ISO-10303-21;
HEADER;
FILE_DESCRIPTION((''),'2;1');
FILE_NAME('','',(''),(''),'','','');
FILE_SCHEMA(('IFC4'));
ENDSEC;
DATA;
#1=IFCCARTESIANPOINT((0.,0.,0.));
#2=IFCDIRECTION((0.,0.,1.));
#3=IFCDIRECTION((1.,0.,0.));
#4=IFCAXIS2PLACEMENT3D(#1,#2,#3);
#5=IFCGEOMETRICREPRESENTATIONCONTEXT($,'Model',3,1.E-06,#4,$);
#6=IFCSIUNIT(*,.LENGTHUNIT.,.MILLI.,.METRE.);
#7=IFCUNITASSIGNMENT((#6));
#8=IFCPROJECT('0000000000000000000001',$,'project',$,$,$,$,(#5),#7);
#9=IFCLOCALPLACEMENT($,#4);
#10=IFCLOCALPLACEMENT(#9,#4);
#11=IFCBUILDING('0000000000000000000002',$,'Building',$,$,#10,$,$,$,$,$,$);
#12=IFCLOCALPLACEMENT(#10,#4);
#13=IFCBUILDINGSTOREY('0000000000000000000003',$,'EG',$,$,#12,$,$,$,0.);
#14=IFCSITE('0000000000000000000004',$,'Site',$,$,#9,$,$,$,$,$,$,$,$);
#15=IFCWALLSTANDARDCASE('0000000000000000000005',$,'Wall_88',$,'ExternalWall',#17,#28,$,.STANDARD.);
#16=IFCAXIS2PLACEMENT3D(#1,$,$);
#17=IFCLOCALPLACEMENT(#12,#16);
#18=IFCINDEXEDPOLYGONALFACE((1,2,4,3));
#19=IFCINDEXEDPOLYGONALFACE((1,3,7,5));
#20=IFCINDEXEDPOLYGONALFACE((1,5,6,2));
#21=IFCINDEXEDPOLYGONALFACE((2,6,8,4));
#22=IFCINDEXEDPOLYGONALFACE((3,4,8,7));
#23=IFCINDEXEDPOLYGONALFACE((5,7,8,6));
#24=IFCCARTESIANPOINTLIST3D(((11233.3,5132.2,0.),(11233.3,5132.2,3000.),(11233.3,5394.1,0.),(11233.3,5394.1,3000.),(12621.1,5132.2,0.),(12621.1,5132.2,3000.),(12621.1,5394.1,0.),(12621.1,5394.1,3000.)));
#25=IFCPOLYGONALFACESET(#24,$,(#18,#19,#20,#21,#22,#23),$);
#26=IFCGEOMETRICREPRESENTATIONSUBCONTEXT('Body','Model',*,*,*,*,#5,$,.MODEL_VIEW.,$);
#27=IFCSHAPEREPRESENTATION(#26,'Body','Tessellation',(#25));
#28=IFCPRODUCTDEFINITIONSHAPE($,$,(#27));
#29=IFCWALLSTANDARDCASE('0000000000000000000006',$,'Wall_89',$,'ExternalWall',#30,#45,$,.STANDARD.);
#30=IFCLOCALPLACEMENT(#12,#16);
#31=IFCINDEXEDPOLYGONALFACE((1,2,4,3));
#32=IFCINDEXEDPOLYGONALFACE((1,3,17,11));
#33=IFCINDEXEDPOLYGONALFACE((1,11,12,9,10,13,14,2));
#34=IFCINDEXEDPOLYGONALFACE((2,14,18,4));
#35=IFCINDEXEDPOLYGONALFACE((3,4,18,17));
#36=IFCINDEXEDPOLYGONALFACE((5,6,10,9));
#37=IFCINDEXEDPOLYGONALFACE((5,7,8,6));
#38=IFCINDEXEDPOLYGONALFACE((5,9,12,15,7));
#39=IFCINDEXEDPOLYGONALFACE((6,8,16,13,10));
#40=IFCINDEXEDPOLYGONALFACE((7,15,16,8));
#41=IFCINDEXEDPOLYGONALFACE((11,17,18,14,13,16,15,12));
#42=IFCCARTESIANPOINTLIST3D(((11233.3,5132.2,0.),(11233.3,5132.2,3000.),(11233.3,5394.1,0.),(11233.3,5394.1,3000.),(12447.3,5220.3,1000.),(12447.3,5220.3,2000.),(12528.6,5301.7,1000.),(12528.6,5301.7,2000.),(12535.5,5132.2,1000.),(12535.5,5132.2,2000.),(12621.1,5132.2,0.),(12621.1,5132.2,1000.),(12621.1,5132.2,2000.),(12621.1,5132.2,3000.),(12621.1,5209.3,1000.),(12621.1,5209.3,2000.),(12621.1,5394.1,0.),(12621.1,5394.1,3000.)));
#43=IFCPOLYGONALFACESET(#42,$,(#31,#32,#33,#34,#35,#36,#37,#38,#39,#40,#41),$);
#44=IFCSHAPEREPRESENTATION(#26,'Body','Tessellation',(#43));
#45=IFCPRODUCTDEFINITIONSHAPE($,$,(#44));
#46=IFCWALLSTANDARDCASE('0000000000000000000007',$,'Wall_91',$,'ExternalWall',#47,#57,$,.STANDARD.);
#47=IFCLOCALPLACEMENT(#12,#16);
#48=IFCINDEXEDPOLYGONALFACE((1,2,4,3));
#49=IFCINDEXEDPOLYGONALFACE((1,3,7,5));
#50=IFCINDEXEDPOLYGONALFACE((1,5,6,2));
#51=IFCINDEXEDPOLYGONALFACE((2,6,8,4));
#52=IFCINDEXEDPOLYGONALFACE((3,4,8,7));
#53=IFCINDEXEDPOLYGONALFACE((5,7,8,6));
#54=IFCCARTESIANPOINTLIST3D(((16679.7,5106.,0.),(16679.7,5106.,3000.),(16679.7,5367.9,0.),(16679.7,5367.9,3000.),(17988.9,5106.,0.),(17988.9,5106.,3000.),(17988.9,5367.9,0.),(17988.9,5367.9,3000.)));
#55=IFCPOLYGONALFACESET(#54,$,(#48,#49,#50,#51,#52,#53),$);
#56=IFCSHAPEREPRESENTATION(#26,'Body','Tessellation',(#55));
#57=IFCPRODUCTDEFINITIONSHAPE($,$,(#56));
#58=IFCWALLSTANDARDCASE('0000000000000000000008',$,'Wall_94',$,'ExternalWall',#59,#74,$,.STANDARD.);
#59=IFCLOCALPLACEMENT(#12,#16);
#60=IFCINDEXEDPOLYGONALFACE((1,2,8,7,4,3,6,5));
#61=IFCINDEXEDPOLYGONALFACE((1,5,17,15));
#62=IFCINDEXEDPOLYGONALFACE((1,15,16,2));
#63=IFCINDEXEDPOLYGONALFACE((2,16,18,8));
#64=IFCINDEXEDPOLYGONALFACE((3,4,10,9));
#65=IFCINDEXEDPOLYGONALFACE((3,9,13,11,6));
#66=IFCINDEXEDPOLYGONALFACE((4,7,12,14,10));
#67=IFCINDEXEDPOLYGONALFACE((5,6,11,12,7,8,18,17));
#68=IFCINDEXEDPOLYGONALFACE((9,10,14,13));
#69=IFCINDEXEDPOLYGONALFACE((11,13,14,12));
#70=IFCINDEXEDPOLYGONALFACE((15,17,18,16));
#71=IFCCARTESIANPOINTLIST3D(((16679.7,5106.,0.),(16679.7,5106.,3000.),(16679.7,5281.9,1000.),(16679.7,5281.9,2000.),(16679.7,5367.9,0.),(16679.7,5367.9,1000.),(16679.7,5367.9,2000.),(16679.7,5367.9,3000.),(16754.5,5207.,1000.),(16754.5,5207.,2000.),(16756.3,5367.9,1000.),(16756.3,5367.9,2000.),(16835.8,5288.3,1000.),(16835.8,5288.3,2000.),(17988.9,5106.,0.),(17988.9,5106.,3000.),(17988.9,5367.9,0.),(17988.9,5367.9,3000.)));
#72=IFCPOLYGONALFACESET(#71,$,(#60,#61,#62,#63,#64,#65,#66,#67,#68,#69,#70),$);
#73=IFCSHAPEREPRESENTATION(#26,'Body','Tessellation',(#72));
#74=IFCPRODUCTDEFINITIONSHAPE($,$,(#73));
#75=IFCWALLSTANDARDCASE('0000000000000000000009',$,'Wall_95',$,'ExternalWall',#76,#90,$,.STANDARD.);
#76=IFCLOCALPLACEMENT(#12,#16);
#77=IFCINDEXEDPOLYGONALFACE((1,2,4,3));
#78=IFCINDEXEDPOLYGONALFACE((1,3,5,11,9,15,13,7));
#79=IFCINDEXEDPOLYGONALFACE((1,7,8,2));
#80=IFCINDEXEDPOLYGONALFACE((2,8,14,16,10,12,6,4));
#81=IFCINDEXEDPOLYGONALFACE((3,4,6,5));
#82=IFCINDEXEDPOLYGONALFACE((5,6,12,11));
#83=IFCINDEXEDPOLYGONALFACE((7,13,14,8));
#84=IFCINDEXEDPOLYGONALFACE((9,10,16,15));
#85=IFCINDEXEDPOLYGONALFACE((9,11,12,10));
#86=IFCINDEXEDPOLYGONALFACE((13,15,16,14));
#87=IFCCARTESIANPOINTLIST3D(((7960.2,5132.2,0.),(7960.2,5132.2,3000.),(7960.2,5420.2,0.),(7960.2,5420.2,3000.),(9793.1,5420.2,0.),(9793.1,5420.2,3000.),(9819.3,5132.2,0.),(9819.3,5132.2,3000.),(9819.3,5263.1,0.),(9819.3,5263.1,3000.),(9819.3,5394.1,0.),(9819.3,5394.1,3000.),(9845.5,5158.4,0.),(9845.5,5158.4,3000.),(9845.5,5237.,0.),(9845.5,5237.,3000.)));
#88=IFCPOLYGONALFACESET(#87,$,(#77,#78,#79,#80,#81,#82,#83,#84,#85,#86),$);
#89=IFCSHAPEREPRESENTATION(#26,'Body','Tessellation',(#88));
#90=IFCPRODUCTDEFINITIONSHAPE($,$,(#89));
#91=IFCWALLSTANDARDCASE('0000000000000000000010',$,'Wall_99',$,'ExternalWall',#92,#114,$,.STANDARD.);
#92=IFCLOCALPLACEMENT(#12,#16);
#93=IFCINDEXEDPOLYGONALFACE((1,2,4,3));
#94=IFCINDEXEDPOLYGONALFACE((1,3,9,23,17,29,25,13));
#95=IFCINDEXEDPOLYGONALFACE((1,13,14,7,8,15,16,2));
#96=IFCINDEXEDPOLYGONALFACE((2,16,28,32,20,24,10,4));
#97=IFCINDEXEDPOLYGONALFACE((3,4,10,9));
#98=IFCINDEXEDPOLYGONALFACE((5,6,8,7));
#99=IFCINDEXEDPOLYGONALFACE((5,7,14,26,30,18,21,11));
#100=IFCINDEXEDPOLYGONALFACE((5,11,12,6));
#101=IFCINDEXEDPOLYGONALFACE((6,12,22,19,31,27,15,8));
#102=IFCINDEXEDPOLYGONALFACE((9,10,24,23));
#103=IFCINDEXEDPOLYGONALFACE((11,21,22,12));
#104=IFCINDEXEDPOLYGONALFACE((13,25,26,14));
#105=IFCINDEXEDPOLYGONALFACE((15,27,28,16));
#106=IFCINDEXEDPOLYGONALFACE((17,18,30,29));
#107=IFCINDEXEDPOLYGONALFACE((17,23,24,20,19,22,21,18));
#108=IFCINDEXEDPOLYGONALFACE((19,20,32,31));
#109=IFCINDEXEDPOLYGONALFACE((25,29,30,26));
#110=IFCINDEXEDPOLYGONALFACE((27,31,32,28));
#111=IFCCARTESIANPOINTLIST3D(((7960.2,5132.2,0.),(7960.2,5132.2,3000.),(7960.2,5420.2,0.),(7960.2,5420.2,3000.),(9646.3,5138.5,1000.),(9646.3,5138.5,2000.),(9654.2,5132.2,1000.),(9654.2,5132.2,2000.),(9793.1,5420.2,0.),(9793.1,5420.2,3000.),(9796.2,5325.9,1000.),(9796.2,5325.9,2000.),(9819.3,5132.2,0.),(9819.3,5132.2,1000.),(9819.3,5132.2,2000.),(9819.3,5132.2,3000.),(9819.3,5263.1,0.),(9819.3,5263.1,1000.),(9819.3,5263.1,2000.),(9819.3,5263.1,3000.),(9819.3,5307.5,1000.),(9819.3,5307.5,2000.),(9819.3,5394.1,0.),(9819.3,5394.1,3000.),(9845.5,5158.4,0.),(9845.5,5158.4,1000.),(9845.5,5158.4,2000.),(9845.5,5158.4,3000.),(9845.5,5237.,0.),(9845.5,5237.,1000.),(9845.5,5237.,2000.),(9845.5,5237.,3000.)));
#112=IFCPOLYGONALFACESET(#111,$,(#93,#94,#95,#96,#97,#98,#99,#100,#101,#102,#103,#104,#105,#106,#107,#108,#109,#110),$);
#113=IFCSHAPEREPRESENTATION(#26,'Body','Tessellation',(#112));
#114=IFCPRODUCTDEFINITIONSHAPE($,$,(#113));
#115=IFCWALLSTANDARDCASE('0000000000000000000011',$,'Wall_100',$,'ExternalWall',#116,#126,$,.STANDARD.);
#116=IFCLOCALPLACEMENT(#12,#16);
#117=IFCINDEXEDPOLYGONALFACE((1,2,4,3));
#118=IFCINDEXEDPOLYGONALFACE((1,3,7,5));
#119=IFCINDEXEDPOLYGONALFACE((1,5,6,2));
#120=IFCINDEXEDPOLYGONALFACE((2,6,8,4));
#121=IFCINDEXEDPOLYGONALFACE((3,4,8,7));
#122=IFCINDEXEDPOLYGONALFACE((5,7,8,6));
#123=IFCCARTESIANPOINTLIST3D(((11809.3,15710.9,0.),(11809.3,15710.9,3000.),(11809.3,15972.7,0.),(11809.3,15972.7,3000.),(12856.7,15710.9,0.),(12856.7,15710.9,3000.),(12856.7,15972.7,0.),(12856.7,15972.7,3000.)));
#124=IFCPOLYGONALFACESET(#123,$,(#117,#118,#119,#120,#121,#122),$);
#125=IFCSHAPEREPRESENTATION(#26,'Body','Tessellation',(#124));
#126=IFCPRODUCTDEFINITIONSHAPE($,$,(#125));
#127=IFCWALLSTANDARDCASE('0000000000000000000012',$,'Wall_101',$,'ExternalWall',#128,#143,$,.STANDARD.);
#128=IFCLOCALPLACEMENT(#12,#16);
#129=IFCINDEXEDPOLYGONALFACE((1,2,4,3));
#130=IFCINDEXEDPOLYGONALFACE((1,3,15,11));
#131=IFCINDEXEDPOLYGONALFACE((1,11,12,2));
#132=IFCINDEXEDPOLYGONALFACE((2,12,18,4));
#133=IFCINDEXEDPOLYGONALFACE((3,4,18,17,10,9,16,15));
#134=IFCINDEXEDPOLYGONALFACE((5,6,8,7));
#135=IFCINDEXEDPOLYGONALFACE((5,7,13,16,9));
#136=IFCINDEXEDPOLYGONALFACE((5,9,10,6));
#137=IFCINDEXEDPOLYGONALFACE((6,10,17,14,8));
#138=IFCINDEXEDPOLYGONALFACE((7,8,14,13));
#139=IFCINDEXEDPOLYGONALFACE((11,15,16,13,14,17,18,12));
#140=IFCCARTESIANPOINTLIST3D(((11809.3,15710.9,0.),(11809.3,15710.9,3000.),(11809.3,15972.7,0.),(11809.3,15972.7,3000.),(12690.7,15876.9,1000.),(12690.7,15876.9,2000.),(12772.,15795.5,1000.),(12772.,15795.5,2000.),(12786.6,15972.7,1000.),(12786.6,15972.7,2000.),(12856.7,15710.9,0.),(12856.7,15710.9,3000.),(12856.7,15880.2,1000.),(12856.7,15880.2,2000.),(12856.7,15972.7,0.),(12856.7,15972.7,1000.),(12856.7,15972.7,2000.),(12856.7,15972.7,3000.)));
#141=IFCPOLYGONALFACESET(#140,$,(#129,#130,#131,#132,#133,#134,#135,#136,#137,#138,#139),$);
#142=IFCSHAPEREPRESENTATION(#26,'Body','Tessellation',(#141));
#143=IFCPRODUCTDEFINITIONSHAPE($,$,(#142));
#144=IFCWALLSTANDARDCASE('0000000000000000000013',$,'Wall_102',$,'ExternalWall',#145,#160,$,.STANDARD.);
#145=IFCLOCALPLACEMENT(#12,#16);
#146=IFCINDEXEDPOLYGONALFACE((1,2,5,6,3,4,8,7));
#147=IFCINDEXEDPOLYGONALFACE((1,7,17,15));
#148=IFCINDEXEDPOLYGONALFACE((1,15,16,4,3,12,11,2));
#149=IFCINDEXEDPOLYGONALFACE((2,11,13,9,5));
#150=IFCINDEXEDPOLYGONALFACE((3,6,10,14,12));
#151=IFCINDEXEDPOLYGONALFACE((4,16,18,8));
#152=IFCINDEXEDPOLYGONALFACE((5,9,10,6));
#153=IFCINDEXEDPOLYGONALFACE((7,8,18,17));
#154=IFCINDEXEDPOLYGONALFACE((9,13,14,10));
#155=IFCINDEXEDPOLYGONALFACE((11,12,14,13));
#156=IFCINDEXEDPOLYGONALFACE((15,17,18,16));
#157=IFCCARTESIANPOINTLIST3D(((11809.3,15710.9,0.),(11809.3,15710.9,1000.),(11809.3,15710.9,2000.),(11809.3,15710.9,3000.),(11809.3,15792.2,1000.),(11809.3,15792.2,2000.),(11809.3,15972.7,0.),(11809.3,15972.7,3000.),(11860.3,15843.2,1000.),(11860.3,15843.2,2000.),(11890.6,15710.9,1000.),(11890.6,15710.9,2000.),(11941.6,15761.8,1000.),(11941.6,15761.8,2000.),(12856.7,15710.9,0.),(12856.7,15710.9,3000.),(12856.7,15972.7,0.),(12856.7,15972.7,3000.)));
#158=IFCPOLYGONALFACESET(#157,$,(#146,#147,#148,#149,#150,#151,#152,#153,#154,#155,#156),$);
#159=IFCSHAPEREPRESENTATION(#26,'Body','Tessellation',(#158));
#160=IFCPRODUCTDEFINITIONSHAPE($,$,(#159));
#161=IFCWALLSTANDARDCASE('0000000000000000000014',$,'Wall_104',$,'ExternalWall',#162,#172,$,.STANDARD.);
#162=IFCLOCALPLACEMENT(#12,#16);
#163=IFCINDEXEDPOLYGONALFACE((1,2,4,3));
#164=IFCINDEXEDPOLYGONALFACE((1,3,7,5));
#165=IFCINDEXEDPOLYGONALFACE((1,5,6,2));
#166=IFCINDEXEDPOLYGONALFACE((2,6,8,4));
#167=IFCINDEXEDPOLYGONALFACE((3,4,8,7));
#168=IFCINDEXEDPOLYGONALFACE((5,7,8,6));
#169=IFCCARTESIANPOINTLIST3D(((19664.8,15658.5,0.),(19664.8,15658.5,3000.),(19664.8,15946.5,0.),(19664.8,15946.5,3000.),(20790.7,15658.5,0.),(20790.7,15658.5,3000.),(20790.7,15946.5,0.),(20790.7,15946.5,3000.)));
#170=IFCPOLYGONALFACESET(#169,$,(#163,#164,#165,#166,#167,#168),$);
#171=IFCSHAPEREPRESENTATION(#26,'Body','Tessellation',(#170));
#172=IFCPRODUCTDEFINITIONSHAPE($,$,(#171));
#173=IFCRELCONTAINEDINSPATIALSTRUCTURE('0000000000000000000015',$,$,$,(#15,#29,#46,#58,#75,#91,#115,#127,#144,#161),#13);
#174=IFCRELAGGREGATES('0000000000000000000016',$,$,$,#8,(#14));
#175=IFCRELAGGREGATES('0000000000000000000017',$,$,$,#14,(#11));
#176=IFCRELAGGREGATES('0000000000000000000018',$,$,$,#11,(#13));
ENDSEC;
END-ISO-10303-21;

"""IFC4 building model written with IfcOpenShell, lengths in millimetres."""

from ifc_helpers import new_model, si_unit, frame, origin_with_axes, place, context, subcontext, project, spatial, polyline, rectangle, outline, extrude, element, save


model = new_model("IFC4")

# Units and contexts
model_context = context("Model", 3, precision=1e-06, world=origin_with_axes())
body_context = subcontext(model_context, "Body", "Model", "MODEL_VIEW")
ifc_project = project(units=[si_unit("LENGTHUNIT", "METRE", prefix="MILLI")], contexts=[model_context])

# Site, building, storey
site_placement = place(None, origin_with_axes())
site = spatial("IfcSite", under=ifc_project, at=site_placement, Name="Site")
building_placement = place(site_placement, origin_with_axes())
building = spatial("IfcBuilding", under=site, at=building_placement, Name="Building")
storey_placement = place(building_placement, origin_with_axes())
storey = spatial("IfcBuildingStorey", under=building, at=storey_placement, Name="EG", Elevation=0.0)

# Wall
wall_1_placement = place(storey_placement, origin_with_axes())
element("IfcWallStandardCase", 1, at=wall_1_placement, inside=storey, Name="Wall_88", ObjectType="ExternalWall", PredefinedType="STANDARD", context=body_context, shape_type="SweptSolid", body=[
    extrude(outline(polyline([(11233.3, 5132.2, 0.0), (11233.3, 5394.1, 0.0), (12621.1, 5394.1, 0.0), (12621.1, 5132.2, 0.0), (11233.3, 5132.2, 0.0)])), origin_with_axes(), (0.0, 0.0, 1.0), 3000.0),
])

# Wall, opening
wall_2_placement = place(storey_placement, origin_with_axes())
wall_2 = element("IfcWallStandardCase", 2, at=wall_2_placement, inside=storey, Name="Wall_89", ObjectType="ExternalWall", PredefinedType="STANDARD", context=body_context, shape_type="SweptSolid", body=[
    extrude(outline(polyline([(11233.3, 5132.2, 0.0), (11233.3, 5394.1, 0.0), (12621.1, 5394.1, 0.0), (12621.1, 5132.2, 0.0), (11233.3, 5132.2, 0.0)])), origin_with_axes(), (0.0, 0.0, 1.0), 3000.0),
])
opening_1_placement = place(wall_2_placement, origin_with_axes())
element("IfcOpeningElement", 3, at=opening_1_placement, inside=storey, cuts=wall_2, context=body_context, shape_type="SweptSolid", body=[
    extrude(rectangle(XDim=1110.9, YDim=115.0), frame((12880.8, 4868.2, 1000.0), z_axis=(0.0, 0.0, 1.0), x_axis=(0.707107, -0.707107, 0.0)), (0.0, 0.0, 1.0), 1000.0),
])

# Wall
for number, where, z_axis, x_axis, name in (
    (4, (0.0, 0.0, 0.0), (0.0, 0.0, 1.0), (1.0, 0.0, 0.0), "Wall_91"),
):
    element("IfcWallStandardCase", number, at=place(storey_placement, frame(where, z_axis=z_axis, x_axis=x_axis)), inside=storey, Name=name, ObjectType="ExternalWall", PredefinedType="STANDARD", context=body_context, shape_type="SweptSolid", body=[
        extrude(outline(polyline([(16679.7, 5106.0, 0.0), (16679.7, 5367.9, 0.0), (17988.9, 5367.9, 0.0), (17988.9, 5106.0, 0.0), (16679.7, 5106.0, 0.0)])), origin_with_axes(), (0.0, 0.0, 1.0), 3000.0),
    ])

# Wall, opening
wall_3_placement = place(storey_placement, origin_with_axes())
wall_3 = element("IfcWallStandardCase", 5, at=wall_3_placement, inside=storey, Name="Wall_94", ObjectType="ExternalWall", PredefinedType="STANDARD", context=body_context, shape_type="SweptSolid", body=[
    extrude(outline(polyline([(16679.7, 5106.0, 0.0), (16679.7, 5367.9, 0.0), (17988.9, 5367.9, 0.0), (17988.9, 5106.0, 0.0), (16679.7, 5106.0, 0.0)])), origin_with_axes(), (0.0, 0.0, 1.0), 3000.0),
])
opening_2_placement = place(wall_3_placement, origin_with_axes())
element("IfcOpeningElement", 6, at=opening_2_placement, inside=storey, cuts=wall_3, context=body_context, shape_type="SweptSolid", body=[
    extrude(rectangle(XDim=1129.4, YDim=115.0), frame((16395.9, 5647.0, 1000.0), z_axis=(0.0, 0.0, 1.0), x_axis=(-0.707107, 0.707107, 0.0)), (0.0, 0.0, 1.0), 1000.0),
])

# Wall
for number, where, z_axis, x_axis, name in (
    (7, (0.0, 0.0, 0.0), (0.0, 0.0, 1.0), (1.0, 0.0, 0.0), "Wall_95"),
):
    element("IfcWallStandardCase", number, at=place(storey_placement, frame(where, z_axis=z_axis, x_axis=x_axis)), inside=storey, Name=name, ObjectType="ExternalWall", PredefinedType="STANDARD", context=body_context, shape_type="SweptSolid", body=[
        extrude(outline(polyline([(7960.2, 5132.2, 0.0), (7960.2, 5420.2, 0.0), (9793.1, 5420.2, 0.0), (9819.3, 5394.1, 0.0), (9819.3, 5263.1, 0.0), (9845.5, 5237.0, 0.0), (9845.5, 5158.4, 0.0), (9819.3, 5132.2, 0.0), (7960.2, 5132.2, 0.0)])), origin_with_axes(), (0.0, 0.0, 1.0), 3000.0),
    ])

# Wall, opening
wall_4_placement = place(storey_placement, origin_with_axes())
wall_4 = element("IfcWallStandardCase", 8, at=wall_4_placement, inside=storey, Name="Wall_99", ObjectType="ExternalWall", PredefinedType="STANDARD", context=body_context, shape_type="SweptSolid", body=[
    extrude(outline(polyline([(7960.2, 5132.2, 0.0), (7960.2, 5420.2, 0.0), (9793.1, 5420.2, 0.0), (9819.3, 5394.1, 0.0), (9819.3, 5263.1, 0.0), (9845.5, 5237.0, 0.0), (9845.5, 5158.4, 0.0), (9819.3, 5132.2, 0.0), (7960.2, 5132.2, 0.0)])), origin_with_axes(), (0.0, 0.0, 1.0), 3000.0),
])
opening_3_placement = place(wall_4_placement, origin_with_axes())
element("IfcOpeningElement", 9, at=opening_3_placement, inside=storey, cuts=wall_4, context=body_context, shape_type="SweptSolid", body=[
    extrude(rectangle(XDim=1202.3, YDim=240.0), frame((10190.7, 4856.7, 1000.0), z_axis=(0.0, 0.0, 1.0), x_axis=(0.780869, -0.624695, 0.0)), (0.0, 0.0, 1.0), 1000.0),
])

# Wall
wall_5_placement = place(storey_placement, origin_with_axes())
element("IfcWallStandardCase", 10, at=wall_5_placement, inside=storey, Name="Wall_100", ObjectType="ExternalWall", PredefinedType="STANDARD", context=body_context, shape_type="SweptSolid", body=[
    extrude(outline(polyline([(11809.3, 15710.9, 0.0), (11809.3, 15972.7, 0.0), (12856.7, 15972.7, 0.0), (12856.7, 15710.9, 0.0), (11809.3, 15710.9, 0.0)])), origin_with_axes(), (0.0, 0.0, 1.0), 3000.0),
])

# Walls, openings
wall_6_placement = place(storey_placement, origin_with_axes())
wall_6 = element("IfcWallStandardCase", 11, at=wall_6_placement, inside=storey, Name="Wall_101", ObjectType="ExternalWall", PredefinedType="STANDARD", context=body_context, shape_type="SweptSolid", body=[
    extrude(outline(polyline([(11809.3, 15710.9, 0.0), (11809.3, 15972.7, 0.0), (12856.7, 15972.7, 0.0), (12856.7, 15710.9, 0.0), (11809.3, 15710.9, 0.0)])), origin_with_axes(), (0.0, 0.0, 1.0), 3000.0),
])
opening_4_placement = place(wall_6_placement, origin_with_axes())
element("IfcOpeningElement", 12, at=opening_4_placement, inside=storey, cuts=wall_6, context=body_context, shape_type="SweptSolid", body=[
    extrude(rectangle(XDim=1092.4, YDim=115.0), frame((13117.6, 16222.4, 1000.0), z_axis=(0.0, 0.0, 1.0), x_axis=(0.707107, 0.707107, 0.0)), (0.0, 0.0, 1.0), 1000.0),
])
wall_7_placement = place(storey_placement, origin_with_axes())
wall_7 = element("IfcWallStandardCase", 13, at=wall_7_placement, inside=storey, Name="Wall_102", ObjectType="ExternalWall", PredefinedType="STANDARD", context=body_context, shape_type="SweptSolid", body=[
    extrude(outline(polyline([(11809.3, 15710.9, 0.0), (11809.3, 15972.7, 0.0), (12856.7, 15972.7, 0.0), (12856.7, 15710.9, 0.0), (11809.3, 15710.9, 0.0)])), origin_with_axes(), (0.0, 0.0, 1.0), 3000.0),
])
opening_5_placement = place(wall_7_placement, origin_with_axes())
element("IfcOpeningElement", 14, at=opening_5_placement, inside=storey, cuts=wall_7, context=body_context, shape_type="SweptSolid", body=[
    extrude(rectangle(XDim=1148.0, YDim=115.0), frame((11495.1, 15396.6, 1000.0), z_axis=(0.0, 0.0, 1.0), x_axis=(-0.707107, -0.707107, 0.0)), (0.0, 0.0, 1.0), 1000.0),
])

# Wall
for number, where, z_axis, x_axis, name in (
    (15, (0.0, 0.0, 0.0), (0.0, 0.0, 1.0), (1.0, 0.0, 0.0), "Wall_104"),
):
    element("IfcWallStandardCase", number, at=place(storey_placement, frame(where, z_axis=z_axis, x_axis=x_axis)), inside=storey, Name=name, ObjectType="ExternalWall", PredefinedType="STANDARD", context=body_context, shape_type="SweptSolid", body=[
        extrude(outline(polyline([(19664.8, 15658.5, 0.0), (19664.8, 15946.5, 0.0), (20790.7, 15946.5, 0.0), (20790.7, 15658.5, 0.0), (19664.8, 15658.5, 0.0)])), origin_with_axes(), (0.0, 0.0, 1.0), 3000.0),
    ])

save(model, "model.ifc")
